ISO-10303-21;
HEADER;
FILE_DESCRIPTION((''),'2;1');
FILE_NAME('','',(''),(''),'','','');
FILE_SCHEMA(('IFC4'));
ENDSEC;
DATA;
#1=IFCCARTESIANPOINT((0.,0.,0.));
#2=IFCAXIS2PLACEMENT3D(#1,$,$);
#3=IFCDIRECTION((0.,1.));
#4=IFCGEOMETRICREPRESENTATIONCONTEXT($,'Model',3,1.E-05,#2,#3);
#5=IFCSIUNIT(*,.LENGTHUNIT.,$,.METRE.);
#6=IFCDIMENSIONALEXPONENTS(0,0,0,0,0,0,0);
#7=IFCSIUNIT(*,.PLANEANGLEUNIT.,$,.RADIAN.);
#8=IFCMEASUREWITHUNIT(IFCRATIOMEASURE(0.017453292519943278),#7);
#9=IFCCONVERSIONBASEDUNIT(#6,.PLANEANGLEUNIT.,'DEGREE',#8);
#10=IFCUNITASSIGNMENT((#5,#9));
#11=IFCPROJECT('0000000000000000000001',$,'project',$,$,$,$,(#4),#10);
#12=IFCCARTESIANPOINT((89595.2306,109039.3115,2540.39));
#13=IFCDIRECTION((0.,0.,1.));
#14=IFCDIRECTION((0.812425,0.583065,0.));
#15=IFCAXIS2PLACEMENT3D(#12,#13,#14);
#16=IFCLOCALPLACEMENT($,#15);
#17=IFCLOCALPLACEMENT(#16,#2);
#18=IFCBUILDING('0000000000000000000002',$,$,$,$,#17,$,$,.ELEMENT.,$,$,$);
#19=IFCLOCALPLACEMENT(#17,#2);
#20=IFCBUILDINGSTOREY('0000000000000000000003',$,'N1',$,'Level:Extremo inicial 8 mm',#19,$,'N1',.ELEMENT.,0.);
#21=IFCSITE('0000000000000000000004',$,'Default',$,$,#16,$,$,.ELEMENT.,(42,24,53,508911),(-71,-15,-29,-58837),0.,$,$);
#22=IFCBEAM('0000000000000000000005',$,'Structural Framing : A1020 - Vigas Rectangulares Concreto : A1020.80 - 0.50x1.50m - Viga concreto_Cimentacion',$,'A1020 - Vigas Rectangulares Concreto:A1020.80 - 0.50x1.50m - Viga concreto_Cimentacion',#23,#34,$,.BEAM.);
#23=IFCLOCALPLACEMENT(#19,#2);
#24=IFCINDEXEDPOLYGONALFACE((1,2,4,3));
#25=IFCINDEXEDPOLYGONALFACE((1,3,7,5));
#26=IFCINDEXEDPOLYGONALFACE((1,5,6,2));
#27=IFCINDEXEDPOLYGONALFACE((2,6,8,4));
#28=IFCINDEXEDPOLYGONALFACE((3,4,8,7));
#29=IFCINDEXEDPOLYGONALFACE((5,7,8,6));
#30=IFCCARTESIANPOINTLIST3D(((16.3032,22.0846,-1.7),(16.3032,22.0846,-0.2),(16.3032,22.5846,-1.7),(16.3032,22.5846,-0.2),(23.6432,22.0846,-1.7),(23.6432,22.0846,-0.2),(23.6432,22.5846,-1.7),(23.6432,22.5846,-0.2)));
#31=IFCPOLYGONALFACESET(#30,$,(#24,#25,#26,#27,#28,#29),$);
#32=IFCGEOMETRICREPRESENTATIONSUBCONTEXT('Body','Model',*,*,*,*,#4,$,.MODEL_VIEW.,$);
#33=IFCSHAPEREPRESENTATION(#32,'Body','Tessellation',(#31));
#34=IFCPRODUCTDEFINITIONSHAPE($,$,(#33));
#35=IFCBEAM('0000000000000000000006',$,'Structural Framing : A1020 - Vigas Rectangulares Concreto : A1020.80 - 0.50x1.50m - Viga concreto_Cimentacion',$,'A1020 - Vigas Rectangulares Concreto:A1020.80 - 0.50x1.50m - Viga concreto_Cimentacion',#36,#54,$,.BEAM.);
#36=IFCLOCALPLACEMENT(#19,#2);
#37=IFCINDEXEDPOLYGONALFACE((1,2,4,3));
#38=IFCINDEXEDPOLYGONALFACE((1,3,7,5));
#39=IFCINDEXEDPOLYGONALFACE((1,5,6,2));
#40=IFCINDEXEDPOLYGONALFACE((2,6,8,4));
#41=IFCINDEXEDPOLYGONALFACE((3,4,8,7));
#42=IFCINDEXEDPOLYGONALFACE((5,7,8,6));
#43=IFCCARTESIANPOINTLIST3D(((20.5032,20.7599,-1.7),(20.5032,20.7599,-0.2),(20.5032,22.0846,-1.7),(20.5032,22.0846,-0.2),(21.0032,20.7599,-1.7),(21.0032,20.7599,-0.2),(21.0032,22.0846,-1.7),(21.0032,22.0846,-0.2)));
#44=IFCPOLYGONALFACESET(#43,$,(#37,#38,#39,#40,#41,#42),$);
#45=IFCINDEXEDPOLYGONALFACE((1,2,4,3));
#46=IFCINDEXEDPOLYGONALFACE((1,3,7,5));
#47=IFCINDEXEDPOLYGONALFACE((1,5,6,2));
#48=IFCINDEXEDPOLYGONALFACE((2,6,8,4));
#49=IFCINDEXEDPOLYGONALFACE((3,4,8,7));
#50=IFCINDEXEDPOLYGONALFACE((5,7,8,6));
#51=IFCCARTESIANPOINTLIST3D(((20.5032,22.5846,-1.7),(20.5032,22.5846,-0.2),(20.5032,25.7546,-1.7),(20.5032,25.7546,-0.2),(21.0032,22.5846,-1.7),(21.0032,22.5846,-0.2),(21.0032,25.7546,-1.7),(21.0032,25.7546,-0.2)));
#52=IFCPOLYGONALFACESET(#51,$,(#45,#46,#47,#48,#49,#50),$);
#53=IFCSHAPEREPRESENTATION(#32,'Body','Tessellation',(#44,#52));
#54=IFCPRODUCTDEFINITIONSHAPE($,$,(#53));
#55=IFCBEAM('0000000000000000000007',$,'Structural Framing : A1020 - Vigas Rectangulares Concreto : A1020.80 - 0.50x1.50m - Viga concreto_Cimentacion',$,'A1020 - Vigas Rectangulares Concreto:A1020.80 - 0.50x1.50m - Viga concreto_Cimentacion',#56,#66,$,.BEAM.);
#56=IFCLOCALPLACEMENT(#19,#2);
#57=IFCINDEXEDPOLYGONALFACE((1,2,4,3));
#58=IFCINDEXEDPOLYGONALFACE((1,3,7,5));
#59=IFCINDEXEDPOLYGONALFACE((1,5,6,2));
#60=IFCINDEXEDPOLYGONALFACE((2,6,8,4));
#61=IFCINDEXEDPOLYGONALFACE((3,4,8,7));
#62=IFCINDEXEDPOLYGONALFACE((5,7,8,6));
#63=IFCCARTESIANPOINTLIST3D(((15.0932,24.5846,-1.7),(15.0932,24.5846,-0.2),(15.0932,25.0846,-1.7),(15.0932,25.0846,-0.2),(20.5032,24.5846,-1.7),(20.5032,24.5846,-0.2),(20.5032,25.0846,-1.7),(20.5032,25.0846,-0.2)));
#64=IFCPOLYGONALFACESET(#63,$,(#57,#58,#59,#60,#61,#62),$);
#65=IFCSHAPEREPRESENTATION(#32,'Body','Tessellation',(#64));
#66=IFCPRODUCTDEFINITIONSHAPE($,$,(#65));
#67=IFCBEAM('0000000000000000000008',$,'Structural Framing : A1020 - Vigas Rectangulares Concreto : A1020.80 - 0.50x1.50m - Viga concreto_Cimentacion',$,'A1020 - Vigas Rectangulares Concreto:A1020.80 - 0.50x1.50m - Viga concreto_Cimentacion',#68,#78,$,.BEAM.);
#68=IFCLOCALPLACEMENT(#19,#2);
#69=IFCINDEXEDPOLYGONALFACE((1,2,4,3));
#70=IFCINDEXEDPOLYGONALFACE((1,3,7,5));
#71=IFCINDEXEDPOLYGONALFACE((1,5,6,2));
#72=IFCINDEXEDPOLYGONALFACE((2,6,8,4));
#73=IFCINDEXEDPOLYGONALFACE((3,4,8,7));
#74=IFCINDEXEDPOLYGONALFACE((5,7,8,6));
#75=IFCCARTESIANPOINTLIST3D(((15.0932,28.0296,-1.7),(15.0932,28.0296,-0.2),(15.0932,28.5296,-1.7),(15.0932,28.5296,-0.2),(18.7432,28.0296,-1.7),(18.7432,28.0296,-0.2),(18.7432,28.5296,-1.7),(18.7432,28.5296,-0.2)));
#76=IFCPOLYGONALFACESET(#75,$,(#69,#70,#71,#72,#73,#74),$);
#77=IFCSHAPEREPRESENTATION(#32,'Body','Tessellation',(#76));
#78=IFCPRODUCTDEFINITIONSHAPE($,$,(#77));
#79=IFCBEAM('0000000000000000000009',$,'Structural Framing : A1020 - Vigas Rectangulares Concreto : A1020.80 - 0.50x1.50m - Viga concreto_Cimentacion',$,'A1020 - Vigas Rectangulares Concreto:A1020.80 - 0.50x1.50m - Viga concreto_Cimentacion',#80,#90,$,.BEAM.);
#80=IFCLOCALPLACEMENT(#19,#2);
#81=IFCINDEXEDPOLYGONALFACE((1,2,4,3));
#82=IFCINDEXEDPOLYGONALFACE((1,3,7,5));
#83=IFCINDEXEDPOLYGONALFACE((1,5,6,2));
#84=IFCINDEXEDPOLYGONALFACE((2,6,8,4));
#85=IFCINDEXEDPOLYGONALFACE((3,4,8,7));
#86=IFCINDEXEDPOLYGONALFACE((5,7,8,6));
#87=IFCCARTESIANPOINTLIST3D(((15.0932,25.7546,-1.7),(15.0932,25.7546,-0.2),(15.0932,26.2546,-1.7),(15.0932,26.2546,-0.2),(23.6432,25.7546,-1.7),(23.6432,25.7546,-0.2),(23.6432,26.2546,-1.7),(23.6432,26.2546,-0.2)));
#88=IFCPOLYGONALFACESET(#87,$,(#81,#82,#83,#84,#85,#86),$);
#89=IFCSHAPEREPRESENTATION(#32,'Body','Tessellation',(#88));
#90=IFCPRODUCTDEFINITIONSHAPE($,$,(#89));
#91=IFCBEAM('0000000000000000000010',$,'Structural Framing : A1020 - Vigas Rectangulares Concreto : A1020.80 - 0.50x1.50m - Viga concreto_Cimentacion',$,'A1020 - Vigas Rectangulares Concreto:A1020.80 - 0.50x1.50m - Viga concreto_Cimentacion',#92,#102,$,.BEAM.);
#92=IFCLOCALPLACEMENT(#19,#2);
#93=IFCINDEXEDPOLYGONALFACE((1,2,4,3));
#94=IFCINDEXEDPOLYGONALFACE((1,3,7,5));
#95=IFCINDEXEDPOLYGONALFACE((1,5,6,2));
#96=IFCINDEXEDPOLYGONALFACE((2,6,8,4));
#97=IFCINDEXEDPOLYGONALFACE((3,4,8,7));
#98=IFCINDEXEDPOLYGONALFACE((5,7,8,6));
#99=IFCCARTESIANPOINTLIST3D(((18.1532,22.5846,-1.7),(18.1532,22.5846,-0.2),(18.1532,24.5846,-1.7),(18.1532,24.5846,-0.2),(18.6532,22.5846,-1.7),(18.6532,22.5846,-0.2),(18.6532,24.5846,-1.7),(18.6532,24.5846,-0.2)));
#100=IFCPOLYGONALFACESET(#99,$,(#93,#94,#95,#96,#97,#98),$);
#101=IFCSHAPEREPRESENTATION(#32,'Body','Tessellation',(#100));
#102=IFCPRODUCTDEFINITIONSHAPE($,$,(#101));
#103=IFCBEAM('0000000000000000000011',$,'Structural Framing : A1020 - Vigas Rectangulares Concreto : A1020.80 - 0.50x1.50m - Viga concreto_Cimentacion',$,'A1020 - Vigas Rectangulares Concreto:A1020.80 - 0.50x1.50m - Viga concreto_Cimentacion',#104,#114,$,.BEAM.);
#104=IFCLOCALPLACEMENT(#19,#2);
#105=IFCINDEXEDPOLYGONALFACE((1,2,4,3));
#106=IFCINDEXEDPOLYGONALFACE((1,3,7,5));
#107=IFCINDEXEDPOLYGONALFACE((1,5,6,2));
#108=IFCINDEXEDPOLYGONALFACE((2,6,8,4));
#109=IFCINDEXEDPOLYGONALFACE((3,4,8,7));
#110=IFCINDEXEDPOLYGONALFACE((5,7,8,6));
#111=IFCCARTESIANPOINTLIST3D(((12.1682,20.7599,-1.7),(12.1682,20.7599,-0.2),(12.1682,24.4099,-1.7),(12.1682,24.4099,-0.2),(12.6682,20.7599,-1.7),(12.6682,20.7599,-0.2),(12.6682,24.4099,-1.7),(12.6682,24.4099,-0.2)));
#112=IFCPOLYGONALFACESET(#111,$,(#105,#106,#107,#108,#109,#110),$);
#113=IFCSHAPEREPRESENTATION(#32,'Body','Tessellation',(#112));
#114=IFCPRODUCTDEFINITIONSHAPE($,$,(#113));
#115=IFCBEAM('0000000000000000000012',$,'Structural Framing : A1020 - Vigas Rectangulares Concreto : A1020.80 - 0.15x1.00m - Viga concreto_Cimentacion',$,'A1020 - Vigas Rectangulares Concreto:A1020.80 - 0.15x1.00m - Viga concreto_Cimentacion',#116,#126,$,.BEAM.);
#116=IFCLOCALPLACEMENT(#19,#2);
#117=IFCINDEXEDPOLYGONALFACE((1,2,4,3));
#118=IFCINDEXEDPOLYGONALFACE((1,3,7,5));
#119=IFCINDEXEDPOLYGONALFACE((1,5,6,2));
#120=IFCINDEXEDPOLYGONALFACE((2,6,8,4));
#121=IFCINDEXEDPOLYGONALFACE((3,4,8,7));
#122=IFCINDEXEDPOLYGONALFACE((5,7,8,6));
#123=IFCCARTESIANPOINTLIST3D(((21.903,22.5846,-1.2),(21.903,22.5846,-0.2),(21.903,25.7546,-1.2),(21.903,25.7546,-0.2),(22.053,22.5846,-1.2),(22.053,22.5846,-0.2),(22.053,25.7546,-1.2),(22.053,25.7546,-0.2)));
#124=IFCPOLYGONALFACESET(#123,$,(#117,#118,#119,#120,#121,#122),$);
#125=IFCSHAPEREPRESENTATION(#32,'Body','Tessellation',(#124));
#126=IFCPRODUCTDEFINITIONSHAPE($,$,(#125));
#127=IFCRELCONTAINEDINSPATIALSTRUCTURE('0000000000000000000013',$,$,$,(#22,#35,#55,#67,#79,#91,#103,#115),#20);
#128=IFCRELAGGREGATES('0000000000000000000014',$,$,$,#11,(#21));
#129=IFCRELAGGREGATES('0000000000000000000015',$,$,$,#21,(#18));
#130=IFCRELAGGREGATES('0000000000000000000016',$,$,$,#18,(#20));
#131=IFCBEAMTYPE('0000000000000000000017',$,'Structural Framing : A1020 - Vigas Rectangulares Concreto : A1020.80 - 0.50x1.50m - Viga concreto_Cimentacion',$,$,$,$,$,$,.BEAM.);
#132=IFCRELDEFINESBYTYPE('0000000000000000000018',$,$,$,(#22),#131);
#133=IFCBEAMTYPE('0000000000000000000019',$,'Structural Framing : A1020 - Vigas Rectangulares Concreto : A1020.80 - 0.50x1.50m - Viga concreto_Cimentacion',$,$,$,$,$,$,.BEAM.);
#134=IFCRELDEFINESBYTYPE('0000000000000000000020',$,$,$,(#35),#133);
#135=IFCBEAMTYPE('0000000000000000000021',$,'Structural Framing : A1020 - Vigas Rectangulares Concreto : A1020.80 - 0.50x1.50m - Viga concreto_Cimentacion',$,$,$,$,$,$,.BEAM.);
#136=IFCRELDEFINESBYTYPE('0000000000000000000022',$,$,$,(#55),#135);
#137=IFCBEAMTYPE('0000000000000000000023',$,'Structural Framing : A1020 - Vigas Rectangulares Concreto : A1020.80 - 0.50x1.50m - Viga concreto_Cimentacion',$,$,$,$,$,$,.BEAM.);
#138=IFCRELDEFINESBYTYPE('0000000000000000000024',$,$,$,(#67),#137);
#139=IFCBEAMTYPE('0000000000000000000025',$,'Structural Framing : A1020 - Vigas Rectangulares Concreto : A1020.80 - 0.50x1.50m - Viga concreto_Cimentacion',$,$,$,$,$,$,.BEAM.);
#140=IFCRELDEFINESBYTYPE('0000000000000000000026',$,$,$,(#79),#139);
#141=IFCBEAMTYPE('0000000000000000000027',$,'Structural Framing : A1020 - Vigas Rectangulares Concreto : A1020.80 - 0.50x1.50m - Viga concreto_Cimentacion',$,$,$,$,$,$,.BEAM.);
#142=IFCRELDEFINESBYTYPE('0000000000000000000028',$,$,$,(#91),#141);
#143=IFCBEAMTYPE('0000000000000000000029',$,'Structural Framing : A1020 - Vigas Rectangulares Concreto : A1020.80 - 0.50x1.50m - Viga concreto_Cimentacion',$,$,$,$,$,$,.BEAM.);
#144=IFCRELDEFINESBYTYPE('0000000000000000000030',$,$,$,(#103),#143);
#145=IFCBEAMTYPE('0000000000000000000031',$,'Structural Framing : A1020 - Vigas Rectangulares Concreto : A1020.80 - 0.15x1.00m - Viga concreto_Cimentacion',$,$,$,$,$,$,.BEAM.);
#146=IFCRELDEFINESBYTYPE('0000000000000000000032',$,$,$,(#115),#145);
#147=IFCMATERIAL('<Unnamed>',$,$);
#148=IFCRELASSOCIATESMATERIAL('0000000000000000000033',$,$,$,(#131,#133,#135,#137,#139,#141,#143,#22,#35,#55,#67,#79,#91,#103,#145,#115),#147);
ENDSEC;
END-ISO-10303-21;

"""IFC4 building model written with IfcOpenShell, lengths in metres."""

from ifc_helpers import new_model, entity, si_unit, converted_unit, direction, frame, frame_2d, origin, place, context, subcontext, project, spatial, polyline, segment, composite_curve, rectangle, outline, extrude, source, transform, mapped, material, material_profile, profile_set, profile_usage, type_object, type_shapes, element, save


model = new_model("IFC4")

# Units and contexts
model_context = context("Model", 3, precision=1e-05, world=origin(), true_north=direction((0.0, 1.0)))
body_context = subcontext(model_context, "Body", "Model", "MODEL_VIEW")
ifc_project = project(units=[si_unit("LENGTHUNIT", "METRE"), converted_unit("PLANEANGLEUNIT", "DEGREE", entity("IfcRatioMeasure", 0.017453292519943278), si_unit("PLANEANGLEUNIT", "RADIAN"), dimensions=[0, 0, 0, 0, 0, 0, 0])], contexts=[model_context])

# Site, building, storey
site_placement = place(None, frame((89595.2306, 109039.3115, 2540.39), z_axis=(0.0, 0.0, 1.0), x_axis=(0.812425, 0.583065, 0.0)))
site = spatial("IfcSite", under=ifc_project, at=site_placement, Name="Default", CompositionType="ELEMENT", RefLatitude=(42, 24, 53, 508911), RefLongitude=(-71, -15, -29, -58837), RefElevation=0.0)
building_placement = place(site_placement, origin())
building = spatial("IfcBuilding", under=site, at=building_placement, CompositionType="ELEMENT")
storey_placement = place(building_placement, origin())
storey = spatial("IfcBuildingStorey", under=building, at=storey_placement, Name="N1", ObjectType="Level:Extremo inicial 8 mm", LongName="N1", CompositionType="ELEMENT", Elevation=0.0)

# Beams
ifc_material = material(Name="<Unnamed>")
ifc_material_profile_1 = material_profile(ifc_material, outline(composite_curve([segment(polyline([(0.25, 0.75, 0.0), (0.25, -0.75, 0.0)]), True, "CONTINUOUS"), segment(polyline([(0.25, -0.75, 0.0), (-0.25, -0.75, 0.0)]), True, "CONTINUOUS"), segment(polyline([(-0.25, -0.75, 0.0), (-0.25, 0.75, 0.0)]), True, "CONTINUOUS"), segment(polyline([(-0.25, 0.75, 0.0), (0.25, 0.75, 0.0)]), True, "CONTINUOUS")], self_intersect=False), kind="CURVE"), Name="A1020.80 - 0.50x1.50m - Viga concreto_Cimentacion")
ifc_material_profile_2 = material_profile(ifc_material, outline(composite_curve([segment(polyline([(-5.3373, 0.25, 0.75), (-5.3373, 0.25, -0.75)]), True, "CONTINUOUS"), segment(polyline([(-5.3373, 0.25, -0.75), (-5.3373, -0.25, -0.75)]), True, "CONTINUOUS"), segment(polyline([(-5.3373, -0.25, -0.75), (-5.3373, -0.25, 0.75)]), True, "CONTINUOUS"), segment(polyline([(-5.3373, -0.25, 0.75), (-5.3373, 0.25, 0.75)]), True, "CONTINUOUS")], self_intersect=False), kind="CURVE"), Name="A1020.80 - 0.50x1.50m - Viga concreto_Cimentacion")
ifc_profile_set_1 = profile_set([ifc_material_profile_1, ifc_material_profile_2], Name="A1020.80 - 0.50x1.50m - Viga concreto_Cimentacion")
ifc_profile_usage_1 = profile_usage(ifc_profile_set_1, cardinal=8)
beam_type_1 = type_object("IfcBeamType", Name="Structural Framing : A1020 - Vigas Rectangulares Concreto : A1020.80 - 0.50x1.50m - Viga concreto_Cimentacion", PredefinedType="BEAM", material=ifc_profile_set_1)
shared_shape_1 = source(origin(), body_context, "Body", "SweptSolid", [
    extrude(rectangle(XDim=1.5, YDim=0.5, at=frame_2d((0.0, 0.0), x_axis=(1.0, 0.0))), frame((16.3032, 22.3346, -0.95), z_axis=(1.0, 0.0, 0.0), x_axis=(0.0, 0.0, -1.0)), (0.0, 0.0, 1.0), 7.34),
])
type_shapes(beam_type_1, [shared_shape_1])
beam_1_placement = place(storey_placement, origin())
element("IfcBeam", 1, at=beam_1_placement, inside=storey, type_object=beam_type_1, material=ifc_profile_usage_1, Name="Structural Framing : A1020 - Vigas Rectangulares Concreto : A1020.80 - 0.50x1.50m - Viga concreto_Cimentacion", ObjectType="A1020 - Vigas Rectangulares Concreto:A1020.80 - 0.50x1.50m - Viga concreto_Cimentacion", PredefinedType="BEAM", context=body_context, shape_type="MappedRepresentation", body=[
    mapped(shared_shape_1, transform((0.0, 0.0, 0.0), scale=1.0)),
])
ifc_profile_usage_2 = profile_usage(ifc_profile_set_1, cardinal=8)
beam_type_2 = type_object("IfcBeamType", Name="Structural Framing : A1020 - Vigas Rectangulares Concreto : A1020.80 - 0.50x1.50m - Viga concreto_Cimentacion", PredefinedType="BEAM", material=ifc_profile_set_1)
shared_shape_2 = source(origin(), body_context, "Body", "SweptSolid", [
    extrude(rectangle(XDim=1.5, YDim=0.5, at=frame_2d((0.0, 0.0), x_axis=(0.0, 1.0))), frame((20.7532, 20.7599, -0.95), z_axis=(0.0, 1.0, 0.0), x_axis=(-1.0, 0.0, 0.0)), (0.0, 0.0, 1.0), 1.3247),
    extrude(rectangle(XDim=1.5, YDim=0.5, at=frame_2d((0.0, 0.0), x_axis=(0.0, 1.0))), frame((20.7532, 22.5846, -0.95), z_axis=(0.0, 1.0, 0.0), x_axis=(-1.0, 0.0, 0.0)), (0.0, 0.0, 1.0), 3.17),
])
type_shapes(beam_type_2, [shared_shape_2])
beam_2_placement = place(storey_placement, origin())
element("IfcBeam", 2, at=beam_2_placement, inside=storey, type_object=beam_type_2, material=ifc_profile_usage_2, Name="Structural Framing : A1020 - Vigas Rectangulares Concreto : A1020.80 - 0.50x1.50m - Viga concreto_Cimentacion", ObjectType="A1020 - Vigas Rectangulares Concreto:A1020.80 - 0.50x1.50m - Viga concreto_Cimentacion", PredefinedType="BEAM", context=body_context, shape_type="MappedRepresentation", body=[
    mapped(shared_shape_2, transform((0.0, 0.0, 0.0), scale=1.0)),
])
ifc_profile_usage_3 = profile_usage(ifc_profile_set_1, cardinal=8)
beam_type_3 = type_object("IfcBeamType", Name="Structural Framing : A1020 - Vigas Rectangulares Concreto : A1020.80 - 0.50x1.50m - Viga concreto_Cimentacion", PredefinedType="BEAM", material=ifc_profile_set_1)
shared_shape_3 = source(origin(), body_context, "Body", "SweptSolid", [
    extrude(rectangle(XDim=1.5, YDim=0.5, at=frame_2d((0.0, 0.0), x_axis=(1.0, 0.0))), frame((20.5032, 24.8346, -0.95), z_axis=(-1.0, 0.0, 0.0), x_axis=(0.0, 0.0, -1.0)), (0.0, 0.0, 1.0), 5.41),
])
type_shapes(beam_type_3, [shared_shape_3])
beam_3_placement = place(storey_placement, origin())
element("IfcBeam", 3, at=beam_3_placement, inside=storey, type_object=beam_type_3, material=ifc_profile_usage_3, Name="Structural Framing : A1020 - Vigas Rectangulares Concreto : A1020.80 - 0.50x1.50m - Viga concreto_Cimentacion", ObjectType="A1020 - Vigas Rectangulares Concreto:A1020.80 - 0.50x1.50m - Viga concreto_Cimentacion", PredefinedType="BEAM", context=body_context, shape_type="MappedRepresentation", body=[
    mapped(shared_shape_3, transform((0.0, 0.0, 0.0), scale=1.0)),
])
ifc_profile_usage_4 = profile_usage(ifc_profile_set_1, cardinal=8)
beam_type_4 = type_object("IfcBeamType", Name="Structural Framing : A1020 - Vigas Rectangulares Concreto : A1020.80 - 0.50x1.50m - Viga concreto_Cimentacion", PredefinedType="BEAM", material=ifc_profile_set_1)
shared_shape_4 = source(origin(), body_context, "Body", "SweptSolid", [
    extrude(rectangle(XDim=1.5, YDim=0.5, at=frame_2d((0.0, 0.0), x_axis=(1.0, 0.0))), frame((15.0932, 28.2796, -0.95), z_axis=(1.0, 0.0, 0.0), x_axis=(0.0, 0.0, -1.0)), (0.0, 0.0, 1.0), 3.65),
])
type_shapes(beam_type_4, [shared_shape_4])
beam_4_placement = place(storey_placement, origin())
element("IfcBeam", 4, at=beam_4_placement, inside=storey, type_object=beam_type_4, material=ifc_profile_usage_4, Name="Structural Framing : A1020 - Vigas Rectangulares Concreto : A1020.80 - 0.50x1.50m - Viga concreto_Cimentacion", ObjectType="A1020 - Vigas Rectangulares Concreto:A1020.80 - 0.50x1.50m - Viga concreto_Cimentacion", PredefinedType="BEAM", context=body_context, shape_type="MappedRepresentation", body=[
    mapped(shared_shape_4, transform((0.0, 0.0, 0.0), scale=1.0)),
])
ifc_profile_usage_5 = profile_usage(ifc_profile_set_1, cardinal=8)
beam_type_5 = type_object("IfcBeamType", Name="Structural Framing : A1020 - Vigas Rectangulares Concreto : A1020.80 - 0.50x1.50m - Viga concreto_Cimentacion", PredefinedType="BEAM", material=ifc_profile_set_1)
shared_shape_5 = source(origin(), body_context, "Body", "SweptSolid", [
    extrude(rectangle(XDim=1.5, YDim=0.5, at=frame_2d((0.0, 0.0), x_axis=(1.0, 0.0))), frame((15.0932, 26.0046, -0.95), z_axis=(1.0, 0.0, 0.0), x_axis=(0.0, 0.0, -1.0)), (0.0, 0.0, 1.0), 8.55),
])
type_shapes(beam_type_5, [shared_shape_5])
beam_5_placement = place(storey_placement, origin())
element("IfcBeam", 5, at=beam_5_placement, inside=storey, type_object=beam_type_5, material=ifc_profile_usage_5, Name="Structural Framing : A1020 - Vigas Rectangulares Concreto : A1020.80 - 0.50x1.50m - Viga concreto_Cimentacion", ObjectType="A1020 - Vigas Rectangulares Concreto:A1020.80 - 0.50x1.50m - Viga concreto_Cimentacion", PredefinedType="BEAM", context=body_context, shape_type="MappedRepresentation", body=[
    mapped(shared_shape_5, transform((0.0, 0.0, 0.0), scale=1.0)),
])
ifc_profile_usage_6 = profile_usage(ifc_profile_set_1, cardinal=8)
beam_type_6 = type_object("IfcBeamType", Name="Structural Framing : A1020 - Vigas Rectangulares Concreto : A1020.80 - 0.50x1.50m - Viga concreto_Cimentacion", PredefinedType="BEAM", material=ifc_profile_set_1)
shared_shape_6 = source(origin(), body_context, "Body", "SweptSolid", [
    extrude(rectangle(XDim=1.5, YDim=0.5, at=frame_2d((0.0, 0.0), x_axis=(0.0, 1.0))), frame((18.4032, 22.5846, -0.95), z_axis=(0.0, 1.0, 0.0), x_axis=(-1.0, 0.0, 0.0)), (0.0, 0.0, 1.0), 2.0),
])
type_shapes(beam_type_6, [shared_shape_6])
beam_6_placement = place(storey_placement, origin())
element("IfcBeam", 6, at=beam_6_placement, inside=storey, type_object=beam_type_6, material=ifc_profile_usage_6, Name="Structural Framing : A1020 - Vigas Rectangulares Concreto : A1020.80 - 0.50x1.50m - Viga concreto_Cimentacion", ObjectType="A1020 - Vigas Rectangulares Concreto:A1020.80 - 0.50x1.50m - Viga concreto_Cimentacion", PredefinedType="BEAM", context=body_context, shape_type="MappedRepresentation", body=[
    mapped(shared_shape_6, transform((0.0, 0.0, 0.0), scale=1.0)),
])
ifc_profile_usage_7 = profile_usage(ifc_profile_set_1, cardinal=8)
beam_type_7 = type_object("IfcBeamType", Name="Structural Framing : A1020 - Vigas Rectangulares Concreto : A1020.80 - 0.50x1.50m - Viga concreto_Cimentacion", PredefinedType="BEAM", material=ifc_profile_set_1)
shared_shape_7 = source(origin(), body_context, "Body", "SweptSolid", [
    extrude(rectangle(XDim=1.5, YDim=0.5, at=frame_2d((0.0, 0.0), x_axis=(0.0, 1.0))), frame((12.4182, 24.4099, -0.95), z_axis=(0.0, -1.0, 0.0), x_axis=(-1.0, 0.0, 0.0)), (0.0, 0.0, 1.0), 3.65),
])
type_shapes(beam_type_7, [shared_shape_7])
beam_7_placement = place(storey_placement, origin())
element("IfcBeam", 7, at=beam_7_placement, inside=storey, type_object=beam_type_7, material=ifc_profile_usage_7, Name="Structural Framing : A1020 - Vigas Rectangulares Concreto : A1020.80 - 0.50x1.50m - Viga concreto_Cimentacion", ObjectType="A1020 - Vigas Rectangulares Concreto:A1020.80 - 0.50x1.50m - Viga concreto_Cimentacion", PredefinedType="BEAM", context=body_context, shape_type="MappedRepresentation", body=[
    mapped(shared_shape_7, transform((0.0, 0.0, 0.0), scale=1.0)),
])
ifc_material_profile_3 = material_profile(ifc_material, outline(composite_curve([segment(polyline([(-0.075, -0.5, 0.0), (-0.075, 0.5, 0.0)]), True, "CONTINUOUS"), segment(polyline([(-0.075, 0.5, 0.0), (0.075, 0.5, 0.0)]), True, "CONTINUOUS"), segment(polyline([(0.075, 0.5, 0.0), (0.075, -0.5, 0.0)]), True, "CONTINUOUS"), segment(polyline([(0.075, -0.5, 0.0), (-0.075, -0.5, 0.0)]), True, "CONTINUOUS")], self_intersect=False), kind="CURVE"), Name="A1020.80 - 0.15x1.00m - Viga concreto_Cimentacion")
ifc_material_profile_4 = material_profile(ifc_material, outline(composite_curve([segment(polyline([(1.5723, 0.075, 0.5), (1.5723, 0.075, -0.5)]), True, "CONTINUOUS"), segment(polyline([(1.5723, 0.075, -0.5), (-1.5723, 0.075, -0.5)]), True, "CONTINUOUS"), segment(polyline([(-1.5723, 0.075, -0.5), (-1.5723, 0.075, 0.5)]), True, "CONTINUOUS"), segment(polyline([(-1.5723, 0.075, 0.5), (1.5723, 0.075, 0.5)]), True, "CONTINUOUS")], self_intersect=False), kind="CURVE"), Name="A1020.80 - 0.15x1.00m - Viga concreto_Cimentacion")
ifc_profile_set_2 = profile_set([ifc_material_profile_3, ifc_material_profile_4], Name="A1020.80 - 0.15x1.00m - Viga concreto_Cimentacion")
ifc_profile_usage_8 = profile_usage(ifc_profile_set_2, cardinal=8)
beam_type_8 = type_object("IfcBeamType", Name="Structural Framing : A1020 - Vigas Rectangulares Concreto : A1020.80 - 0.15x1.00m - Viga concreto_Cimentacion", PredefinedType="BEAM", material=ifc_profile_set_2)
shared_shape_8 = source(origin(), body_context, "Body", "SweptSolid", [
    extrude(rectangle(XDim=1.0, YDim=0.15, at=frame_2d((0.0, 0.0), x_axis=(0.0, 1.0))), frame((21.978, 22.5846, -0.7), z_axis=(0.0, 1.0, 0.0), x_axis=(-1.0, 0.0, 0.0)), (0.0, 0.0, 1.0), 3.17),
])
type_shapes(beam_type_8, [shared_shape_8])
beam_8_placement = place(storey_placement, origin())
element("IfcBeam", 8, at=beam_8_placement, inside=storey, type_object=beam_type_8, material=ifc_profile_usage_8, Name="Structural Framing : A1020 - Vigas Rectangulares Concreto : A1020.80 - 0.15x1.00m - Viga concreto_Cimentacion", ObjectType="A1020 - Vigas Rectangulares Concreto:A1020.80 - 0.15x1.00m - Viga concreto_Cimentacion", PredefinedType="BEAM", context=body_context, shape_type="MappedRepresentation", body=[
    mapped(shared_shape_8, transform((0.0, 0.0, 0.0), scale=1.0)),
])

save(model, "model.ifc")
